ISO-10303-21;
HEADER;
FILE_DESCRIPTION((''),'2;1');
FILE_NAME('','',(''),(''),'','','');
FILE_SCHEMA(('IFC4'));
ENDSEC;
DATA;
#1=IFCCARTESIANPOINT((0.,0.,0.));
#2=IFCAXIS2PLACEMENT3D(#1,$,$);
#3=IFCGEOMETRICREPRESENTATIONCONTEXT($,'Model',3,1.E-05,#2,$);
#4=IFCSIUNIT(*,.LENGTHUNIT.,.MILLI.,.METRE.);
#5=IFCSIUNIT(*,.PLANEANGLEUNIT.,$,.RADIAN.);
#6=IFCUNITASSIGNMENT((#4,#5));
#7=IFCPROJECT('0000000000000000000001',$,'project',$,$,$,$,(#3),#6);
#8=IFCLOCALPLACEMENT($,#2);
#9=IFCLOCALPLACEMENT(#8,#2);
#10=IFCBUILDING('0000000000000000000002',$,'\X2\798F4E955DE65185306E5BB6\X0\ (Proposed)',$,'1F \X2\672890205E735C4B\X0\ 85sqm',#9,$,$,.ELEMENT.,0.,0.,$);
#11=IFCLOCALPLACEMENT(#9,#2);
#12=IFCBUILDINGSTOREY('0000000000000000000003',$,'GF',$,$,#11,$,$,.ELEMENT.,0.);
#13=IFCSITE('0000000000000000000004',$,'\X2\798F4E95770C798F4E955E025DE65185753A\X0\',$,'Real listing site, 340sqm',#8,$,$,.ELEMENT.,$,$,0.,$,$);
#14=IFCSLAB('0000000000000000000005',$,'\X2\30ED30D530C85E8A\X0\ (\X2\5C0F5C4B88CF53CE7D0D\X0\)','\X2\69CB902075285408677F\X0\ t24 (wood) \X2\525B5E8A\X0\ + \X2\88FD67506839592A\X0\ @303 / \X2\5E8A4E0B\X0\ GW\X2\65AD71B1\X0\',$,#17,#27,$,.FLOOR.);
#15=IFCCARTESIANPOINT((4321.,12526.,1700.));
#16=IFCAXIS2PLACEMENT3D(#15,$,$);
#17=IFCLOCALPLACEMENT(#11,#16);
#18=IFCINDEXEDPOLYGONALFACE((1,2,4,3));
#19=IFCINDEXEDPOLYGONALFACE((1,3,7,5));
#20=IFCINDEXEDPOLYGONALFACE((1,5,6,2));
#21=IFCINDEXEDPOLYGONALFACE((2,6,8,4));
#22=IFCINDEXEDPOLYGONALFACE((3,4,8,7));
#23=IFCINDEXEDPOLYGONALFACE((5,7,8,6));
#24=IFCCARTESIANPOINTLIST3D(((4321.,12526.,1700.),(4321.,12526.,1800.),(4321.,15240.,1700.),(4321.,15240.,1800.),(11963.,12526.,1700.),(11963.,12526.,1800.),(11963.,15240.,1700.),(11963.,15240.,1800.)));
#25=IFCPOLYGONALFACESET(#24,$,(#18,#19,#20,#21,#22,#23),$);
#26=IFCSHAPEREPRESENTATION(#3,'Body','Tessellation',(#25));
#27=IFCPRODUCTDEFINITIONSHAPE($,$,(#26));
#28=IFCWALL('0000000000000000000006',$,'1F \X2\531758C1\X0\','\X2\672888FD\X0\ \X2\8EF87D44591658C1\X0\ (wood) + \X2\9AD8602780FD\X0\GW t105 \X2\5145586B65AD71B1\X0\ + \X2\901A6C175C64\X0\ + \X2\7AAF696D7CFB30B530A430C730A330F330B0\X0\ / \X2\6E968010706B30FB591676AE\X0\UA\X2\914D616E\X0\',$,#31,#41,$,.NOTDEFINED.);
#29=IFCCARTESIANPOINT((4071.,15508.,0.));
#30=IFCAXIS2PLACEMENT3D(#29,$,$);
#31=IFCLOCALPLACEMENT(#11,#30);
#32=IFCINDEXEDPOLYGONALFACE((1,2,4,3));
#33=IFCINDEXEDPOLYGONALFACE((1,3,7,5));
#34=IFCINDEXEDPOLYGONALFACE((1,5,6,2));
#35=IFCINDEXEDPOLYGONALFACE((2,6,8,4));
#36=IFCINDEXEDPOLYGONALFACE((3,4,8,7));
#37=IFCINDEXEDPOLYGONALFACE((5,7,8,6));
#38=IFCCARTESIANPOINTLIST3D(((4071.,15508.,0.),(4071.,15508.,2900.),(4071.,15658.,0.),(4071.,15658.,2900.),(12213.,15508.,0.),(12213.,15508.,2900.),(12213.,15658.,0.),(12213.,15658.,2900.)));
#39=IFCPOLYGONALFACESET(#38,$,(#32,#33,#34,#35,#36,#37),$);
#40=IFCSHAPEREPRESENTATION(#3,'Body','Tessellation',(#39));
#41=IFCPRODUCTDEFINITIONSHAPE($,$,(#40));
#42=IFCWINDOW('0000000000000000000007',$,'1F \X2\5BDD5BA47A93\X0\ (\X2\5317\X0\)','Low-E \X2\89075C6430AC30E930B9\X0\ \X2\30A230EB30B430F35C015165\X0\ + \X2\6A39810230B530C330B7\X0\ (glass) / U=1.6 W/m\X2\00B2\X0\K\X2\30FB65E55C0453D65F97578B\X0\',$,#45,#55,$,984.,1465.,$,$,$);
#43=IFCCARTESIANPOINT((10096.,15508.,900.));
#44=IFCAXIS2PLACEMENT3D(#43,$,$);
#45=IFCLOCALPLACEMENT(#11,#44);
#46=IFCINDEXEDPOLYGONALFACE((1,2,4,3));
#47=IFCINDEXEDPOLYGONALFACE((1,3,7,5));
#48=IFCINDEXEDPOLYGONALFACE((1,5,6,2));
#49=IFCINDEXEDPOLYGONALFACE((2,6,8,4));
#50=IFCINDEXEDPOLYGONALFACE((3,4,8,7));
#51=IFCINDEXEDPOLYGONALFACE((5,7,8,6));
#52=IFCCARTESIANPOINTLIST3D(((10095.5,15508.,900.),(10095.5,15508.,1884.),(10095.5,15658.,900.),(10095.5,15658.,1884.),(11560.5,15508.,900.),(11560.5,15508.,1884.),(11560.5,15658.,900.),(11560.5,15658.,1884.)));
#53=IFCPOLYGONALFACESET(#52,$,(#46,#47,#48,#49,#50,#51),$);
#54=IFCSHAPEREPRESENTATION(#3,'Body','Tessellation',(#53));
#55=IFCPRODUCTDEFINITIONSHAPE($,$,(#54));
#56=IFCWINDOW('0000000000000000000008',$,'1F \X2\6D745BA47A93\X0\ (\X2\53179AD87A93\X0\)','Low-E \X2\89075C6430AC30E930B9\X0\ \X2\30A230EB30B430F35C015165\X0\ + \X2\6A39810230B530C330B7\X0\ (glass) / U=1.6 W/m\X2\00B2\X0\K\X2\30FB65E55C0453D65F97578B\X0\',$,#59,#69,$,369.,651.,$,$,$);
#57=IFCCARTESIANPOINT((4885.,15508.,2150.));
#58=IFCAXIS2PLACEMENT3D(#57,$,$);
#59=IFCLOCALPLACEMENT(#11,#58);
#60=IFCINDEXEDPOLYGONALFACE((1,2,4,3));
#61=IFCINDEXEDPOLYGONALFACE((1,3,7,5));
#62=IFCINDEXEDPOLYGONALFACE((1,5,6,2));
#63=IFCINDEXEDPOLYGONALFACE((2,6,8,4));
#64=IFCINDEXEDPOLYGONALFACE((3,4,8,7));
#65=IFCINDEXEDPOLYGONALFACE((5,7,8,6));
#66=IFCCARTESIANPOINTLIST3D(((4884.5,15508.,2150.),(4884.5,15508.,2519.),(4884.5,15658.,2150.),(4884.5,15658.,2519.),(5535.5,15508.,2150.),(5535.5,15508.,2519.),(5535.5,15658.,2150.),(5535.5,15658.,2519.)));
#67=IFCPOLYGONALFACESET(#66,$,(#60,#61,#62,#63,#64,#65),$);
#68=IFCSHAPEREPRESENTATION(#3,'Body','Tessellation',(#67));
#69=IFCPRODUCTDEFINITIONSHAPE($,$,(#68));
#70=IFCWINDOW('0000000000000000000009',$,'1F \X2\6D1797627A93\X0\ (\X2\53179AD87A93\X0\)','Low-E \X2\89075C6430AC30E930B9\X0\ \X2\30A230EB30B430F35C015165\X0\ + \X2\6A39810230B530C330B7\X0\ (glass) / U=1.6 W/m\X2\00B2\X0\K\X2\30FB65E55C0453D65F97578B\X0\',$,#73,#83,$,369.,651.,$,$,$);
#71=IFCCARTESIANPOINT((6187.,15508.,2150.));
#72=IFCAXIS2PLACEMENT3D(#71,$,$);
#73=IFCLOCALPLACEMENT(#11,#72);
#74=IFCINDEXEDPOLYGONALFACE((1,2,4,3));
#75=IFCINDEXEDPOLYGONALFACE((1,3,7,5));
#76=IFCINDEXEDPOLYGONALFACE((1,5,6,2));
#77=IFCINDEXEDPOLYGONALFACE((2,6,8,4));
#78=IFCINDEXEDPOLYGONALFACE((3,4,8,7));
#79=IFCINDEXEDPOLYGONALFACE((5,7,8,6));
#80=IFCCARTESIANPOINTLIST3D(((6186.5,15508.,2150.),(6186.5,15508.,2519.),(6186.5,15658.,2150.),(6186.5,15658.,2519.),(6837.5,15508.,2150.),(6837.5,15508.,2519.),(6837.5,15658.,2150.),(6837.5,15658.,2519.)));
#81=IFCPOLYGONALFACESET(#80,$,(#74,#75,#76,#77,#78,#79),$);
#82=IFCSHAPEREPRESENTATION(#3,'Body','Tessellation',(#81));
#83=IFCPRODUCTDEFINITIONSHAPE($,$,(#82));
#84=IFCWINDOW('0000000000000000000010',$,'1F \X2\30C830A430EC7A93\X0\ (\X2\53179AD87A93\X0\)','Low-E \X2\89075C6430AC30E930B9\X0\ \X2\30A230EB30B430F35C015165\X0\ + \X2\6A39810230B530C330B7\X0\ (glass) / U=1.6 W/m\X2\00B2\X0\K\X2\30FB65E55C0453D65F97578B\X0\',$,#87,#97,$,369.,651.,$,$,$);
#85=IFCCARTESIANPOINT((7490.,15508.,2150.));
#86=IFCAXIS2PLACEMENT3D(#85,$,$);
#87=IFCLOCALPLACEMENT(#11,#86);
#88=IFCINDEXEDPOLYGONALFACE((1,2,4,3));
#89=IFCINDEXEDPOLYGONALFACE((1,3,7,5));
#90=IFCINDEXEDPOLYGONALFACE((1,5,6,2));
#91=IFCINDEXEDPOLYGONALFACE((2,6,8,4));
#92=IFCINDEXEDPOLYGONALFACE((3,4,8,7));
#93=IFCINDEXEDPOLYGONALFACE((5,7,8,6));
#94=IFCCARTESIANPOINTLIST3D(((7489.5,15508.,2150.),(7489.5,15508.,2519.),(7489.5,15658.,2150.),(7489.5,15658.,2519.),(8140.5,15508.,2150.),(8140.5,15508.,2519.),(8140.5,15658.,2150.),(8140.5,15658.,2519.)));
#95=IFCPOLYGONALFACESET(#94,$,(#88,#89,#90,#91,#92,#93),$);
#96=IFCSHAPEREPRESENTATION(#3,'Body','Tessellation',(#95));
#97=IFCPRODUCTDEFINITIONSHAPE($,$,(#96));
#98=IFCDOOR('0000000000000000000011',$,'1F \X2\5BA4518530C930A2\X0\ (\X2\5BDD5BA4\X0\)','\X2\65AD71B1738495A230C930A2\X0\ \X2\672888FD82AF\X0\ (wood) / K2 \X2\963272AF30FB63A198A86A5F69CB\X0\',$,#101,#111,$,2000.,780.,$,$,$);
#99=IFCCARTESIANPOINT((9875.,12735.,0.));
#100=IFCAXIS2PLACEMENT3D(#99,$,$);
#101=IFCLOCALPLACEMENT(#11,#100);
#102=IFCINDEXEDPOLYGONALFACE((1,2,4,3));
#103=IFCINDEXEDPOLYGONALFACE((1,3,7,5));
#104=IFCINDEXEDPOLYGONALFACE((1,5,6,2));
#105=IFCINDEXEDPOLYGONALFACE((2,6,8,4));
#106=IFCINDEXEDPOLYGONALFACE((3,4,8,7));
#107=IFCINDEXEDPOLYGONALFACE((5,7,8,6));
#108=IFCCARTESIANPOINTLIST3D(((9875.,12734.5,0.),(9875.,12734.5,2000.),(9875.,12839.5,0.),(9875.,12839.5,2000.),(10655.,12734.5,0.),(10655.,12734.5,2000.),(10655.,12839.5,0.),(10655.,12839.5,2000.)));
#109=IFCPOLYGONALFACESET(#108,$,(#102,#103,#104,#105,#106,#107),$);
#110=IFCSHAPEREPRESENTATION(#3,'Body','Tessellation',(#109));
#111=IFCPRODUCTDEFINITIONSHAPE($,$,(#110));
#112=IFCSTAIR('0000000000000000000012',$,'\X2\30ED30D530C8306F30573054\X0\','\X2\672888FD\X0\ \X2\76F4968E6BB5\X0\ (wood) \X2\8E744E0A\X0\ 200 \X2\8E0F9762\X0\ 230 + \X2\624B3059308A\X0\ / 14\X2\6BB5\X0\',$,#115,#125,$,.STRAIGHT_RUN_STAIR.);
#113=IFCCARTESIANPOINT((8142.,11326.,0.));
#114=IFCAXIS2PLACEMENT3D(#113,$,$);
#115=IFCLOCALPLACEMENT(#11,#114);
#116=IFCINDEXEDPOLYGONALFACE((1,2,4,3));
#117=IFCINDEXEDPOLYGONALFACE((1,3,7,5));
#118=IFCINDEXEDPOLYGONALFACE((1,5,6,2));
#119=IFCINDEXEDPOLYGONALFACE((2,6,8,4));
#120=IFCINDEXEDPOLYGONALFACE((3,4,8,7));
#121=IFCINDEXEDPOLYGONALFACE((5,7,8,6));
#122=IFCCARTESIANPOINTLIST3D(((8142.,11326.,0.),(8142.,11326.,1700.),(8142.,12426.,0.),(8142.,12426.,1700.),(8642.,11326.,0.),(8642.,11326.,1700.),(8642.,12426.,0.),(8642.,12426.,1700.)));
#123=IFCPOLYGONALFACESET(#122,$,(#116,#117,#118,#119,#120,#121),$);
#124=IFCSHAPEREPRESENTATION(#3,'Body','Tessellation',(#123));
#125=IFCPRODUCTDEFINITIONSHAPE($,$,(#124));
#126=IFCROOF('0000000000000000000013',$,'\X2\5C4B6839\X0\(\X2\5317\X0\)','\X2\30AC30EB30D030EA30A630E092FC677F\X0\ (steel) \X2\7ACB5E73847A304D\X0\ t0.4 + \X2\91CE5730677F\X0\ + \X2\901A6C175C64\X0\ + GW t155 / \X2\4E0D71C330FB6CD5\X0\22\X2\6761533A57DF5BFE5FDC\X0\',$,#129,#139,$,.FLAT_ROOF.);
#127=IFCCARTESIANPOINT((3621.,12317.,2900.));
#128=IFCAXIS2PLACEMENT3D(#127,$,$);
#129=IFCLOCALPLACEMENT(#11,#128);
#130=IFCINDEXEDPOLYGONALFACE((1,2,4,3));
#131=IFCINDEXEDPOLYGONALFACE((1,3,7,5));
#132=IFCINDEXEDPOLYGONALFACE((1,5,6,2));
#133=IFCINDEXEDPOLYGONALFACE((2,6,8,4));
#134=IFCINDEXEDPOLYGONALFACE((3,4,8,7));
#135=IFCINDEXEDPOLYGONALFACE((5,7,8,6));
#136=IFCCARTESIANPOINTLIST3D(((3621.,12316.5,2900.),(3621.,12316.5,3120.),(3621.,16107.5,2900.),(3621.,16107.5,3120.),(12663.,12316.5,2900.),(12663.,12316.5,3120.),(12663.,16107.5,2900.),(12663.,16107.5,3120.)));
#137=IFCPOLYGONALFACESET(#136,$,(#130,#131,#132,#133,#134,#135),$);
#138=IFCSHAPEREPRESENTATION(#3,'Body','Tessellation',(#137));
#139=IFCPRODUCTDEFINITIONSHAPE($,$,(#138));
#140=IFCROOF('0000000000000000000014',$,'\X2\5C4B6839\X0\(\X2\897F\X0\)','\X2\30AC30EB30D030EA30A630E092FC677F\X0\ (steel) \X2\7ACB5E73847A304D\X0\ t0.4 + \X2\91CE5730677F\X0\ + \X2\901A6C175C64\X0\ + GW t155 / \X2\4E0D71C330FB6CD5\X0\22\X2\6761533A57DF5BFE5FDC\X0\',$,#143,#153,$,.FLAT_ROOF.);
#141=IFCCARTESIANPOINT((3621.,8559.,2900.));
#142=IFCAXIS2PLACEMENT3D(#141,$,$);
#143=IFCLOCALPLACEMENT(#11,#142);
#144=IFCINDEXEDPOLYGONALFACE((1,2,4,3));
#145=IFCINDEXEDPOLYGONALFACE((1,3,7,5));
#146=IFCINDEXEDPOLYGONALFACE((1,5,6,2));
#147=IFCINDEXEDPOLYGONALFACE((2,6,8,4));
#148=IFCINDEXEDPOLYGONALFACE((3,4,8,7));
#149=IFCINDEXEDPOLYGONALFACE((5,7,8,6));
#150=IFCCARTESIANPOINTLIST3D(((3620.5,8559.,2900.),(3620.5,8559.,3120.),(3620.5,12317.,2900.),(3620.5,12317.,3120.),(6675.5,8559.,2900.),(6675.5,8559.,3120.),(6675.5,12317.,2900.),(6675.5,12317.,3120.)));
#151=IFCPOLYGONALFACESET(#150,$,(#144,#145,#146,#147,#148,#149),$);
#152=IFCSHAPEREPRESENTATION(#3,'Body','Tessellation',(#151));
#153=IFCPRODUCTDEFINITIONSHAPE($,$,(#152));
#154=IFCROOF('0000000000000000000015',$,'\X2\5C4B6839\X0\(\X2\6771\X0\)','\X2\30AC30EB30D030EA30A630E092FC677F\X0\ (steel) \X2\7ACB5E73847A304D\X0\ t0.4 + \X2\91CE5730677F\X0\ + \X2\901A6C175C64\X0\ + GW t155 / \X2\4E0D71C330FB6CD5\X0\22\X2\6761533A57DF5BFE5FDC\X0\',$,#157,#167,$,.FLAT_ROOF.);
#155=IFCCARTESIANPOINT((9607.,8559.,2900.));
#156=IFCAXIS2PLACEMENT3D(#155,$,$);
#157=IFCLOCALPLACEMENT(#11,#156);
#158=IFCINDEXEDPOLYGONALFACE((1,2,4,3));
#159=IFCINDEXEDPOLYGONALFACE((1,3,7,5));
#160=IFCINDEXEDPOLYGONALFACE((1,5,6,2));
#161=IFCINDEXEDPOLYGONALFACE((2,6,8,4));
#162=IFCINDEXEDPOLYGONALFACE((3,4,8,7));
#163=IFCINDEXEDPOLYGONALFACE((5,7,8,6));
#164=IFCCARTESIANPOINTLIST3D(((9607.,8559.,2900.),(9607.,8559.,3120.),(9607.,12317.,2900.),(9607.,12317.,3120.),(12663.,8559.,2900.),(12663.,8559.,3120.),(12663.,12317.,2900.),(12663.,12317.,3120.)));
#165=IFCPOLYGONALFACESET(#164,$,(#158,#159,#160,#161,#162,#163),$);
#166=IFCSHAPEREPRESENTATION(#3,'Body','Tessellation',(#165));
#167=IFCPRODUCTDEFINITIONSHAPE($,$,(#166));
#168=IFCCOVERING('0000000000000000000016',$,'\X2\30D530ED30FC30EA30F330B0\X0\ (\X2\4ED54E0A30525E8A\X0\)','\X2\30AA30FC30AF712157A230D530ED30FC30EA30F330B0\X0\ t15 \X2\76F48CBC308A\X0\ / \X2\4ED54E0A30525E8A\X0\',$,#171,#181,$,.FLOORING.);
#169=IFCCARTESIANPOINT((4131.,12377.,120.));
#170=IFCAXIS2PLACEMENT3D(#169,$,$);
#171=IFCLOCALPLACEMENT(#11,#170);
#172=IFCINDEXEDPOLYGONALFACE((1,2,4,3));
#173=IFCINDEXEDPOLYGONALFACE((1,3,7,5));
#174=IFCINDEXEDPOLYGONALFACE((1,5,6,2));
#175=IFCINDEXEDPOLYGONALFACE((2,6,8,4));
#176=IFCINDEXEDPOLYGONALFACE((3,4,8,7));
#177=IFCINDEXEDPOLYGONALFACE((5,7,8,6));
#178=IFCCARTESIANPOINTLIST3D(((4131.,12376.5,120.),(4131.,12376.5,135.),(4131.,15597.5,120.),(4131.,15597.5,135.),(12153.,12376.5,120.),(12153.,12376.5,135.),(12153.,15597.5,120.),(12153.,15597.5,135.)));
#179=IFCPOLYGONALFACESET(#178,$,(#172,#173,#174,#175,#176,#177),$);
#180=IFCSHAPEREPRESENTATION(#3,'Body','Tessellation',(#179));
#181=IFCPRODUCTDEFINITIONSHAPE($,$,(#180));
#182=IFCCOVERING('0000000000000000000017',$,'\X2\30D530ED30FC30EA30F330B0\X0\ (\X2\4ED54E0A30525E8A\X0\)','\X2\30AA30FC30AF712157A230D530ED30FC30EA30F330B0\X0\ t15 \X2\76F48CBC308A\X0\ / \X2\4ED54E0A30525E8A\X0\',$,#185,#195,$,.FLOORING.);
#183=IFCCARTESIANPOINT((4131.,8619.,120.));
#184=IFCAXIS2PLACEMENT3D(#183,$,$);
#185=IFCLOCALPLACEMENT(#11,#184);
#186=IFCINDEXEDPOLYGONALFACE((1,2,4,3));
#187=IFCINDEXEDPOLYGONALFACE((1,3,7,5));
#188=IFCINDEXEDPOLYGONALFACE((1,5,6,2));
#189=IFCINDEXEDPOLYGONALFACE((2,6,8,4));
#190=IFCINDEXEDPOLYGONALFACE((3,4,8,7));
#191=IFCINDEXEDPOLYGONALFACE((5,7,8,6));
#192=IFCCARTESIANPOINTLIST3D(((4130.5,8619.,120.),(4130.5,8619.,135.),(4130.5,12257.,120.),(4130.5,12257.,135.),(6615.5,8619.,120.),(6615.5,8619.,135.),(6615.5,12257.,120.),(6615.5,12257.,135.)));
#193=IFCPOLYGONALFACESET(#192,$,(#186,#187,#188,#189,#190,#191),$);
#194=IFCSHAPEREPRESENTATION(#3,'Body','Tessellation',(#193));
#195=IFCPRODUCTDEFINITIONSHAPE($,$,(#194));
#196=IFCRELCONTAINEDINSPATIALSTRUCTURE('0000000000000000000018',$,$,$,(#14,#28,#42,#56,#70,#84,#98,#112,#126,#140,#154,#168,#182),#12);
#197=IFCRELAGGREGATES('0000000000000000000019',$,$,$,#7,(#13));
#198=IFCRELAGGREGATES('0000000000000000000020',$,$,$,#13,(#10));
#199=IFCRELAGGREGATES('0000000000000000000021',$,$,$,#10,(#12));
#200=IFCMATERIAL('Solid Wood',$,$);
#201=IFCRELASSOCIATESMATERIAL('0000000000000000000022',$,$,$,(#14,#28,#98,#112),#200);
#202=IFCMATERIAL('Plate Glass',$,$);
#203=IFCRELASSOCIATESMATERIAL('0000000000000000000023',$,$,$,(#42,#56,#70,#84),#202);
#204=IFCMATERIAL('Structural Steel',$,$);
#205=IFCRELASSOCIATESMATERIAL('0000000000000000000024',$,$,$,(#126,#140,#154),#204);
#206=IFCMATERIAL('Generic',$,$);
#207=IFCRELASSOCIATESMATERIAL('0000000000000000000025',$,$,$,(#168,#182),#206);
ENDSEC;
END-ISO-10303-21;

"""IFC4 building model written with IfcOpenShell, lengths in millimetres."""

from ifc_helpers import new_model, si_unit, frame, frame_2d, origin, place, context, project, spatial, rectangle, extrude, material, element, fill, save


model = new_model("IFC4")

# Units and contexts
model_context = context("Model", 3, precision=1e-05, world=origin())
ifc_project = project(units=[si_unit("LENGTHUNIT", "METRE", prefix="MILLI"), si_unit("PLANEANGLEUNIT", "RADIAN")], contexts=[model_context])

# Site, building, storey
site_placement = place(None, origin())
site = spatial("IfcSite", under=ifc_project, at=site_placement, Name="福井県福井市左内町", ObjectType="Real listing site, 340sqm", CompositionType="ELEMENT", RefElevation=0.0)
building_placement = place(site_placement, origin())
building = spatial("IfcBuilding", under=site, at=building_placement, Name="福井左内の家 (Proposed)", ObjectType="1F 木造平屋 85sqm", CompositionType="ELEMENT", ElevationOfRefHeight=0.0, ElevationOfTerrain=0.0)
storey_placement = place(building_placement, origin())
storey = spatial("IfcBuildingStorey", under=building, at=storey_placement, Name="GF", CompositionType="ELEMENT", Elevation=0.0)

# Slab
ifc_material_1 = material(Name="Solid Wood")
slab_1_placement = place(storey_placement, frame((4321.0, 12526.0, 1700.0)))
element("IfcSlab", 1, at=slab_1_placement, inside=storey, material=ifc_material_1, Name="ロフト床 (小屋裏収納)", Description="構造用合板 t24 (wood) 剛床 + 製材根太 @303 / 床下 GW断熱", PredefinedType="FLOOR", context=model_context, shape_type="SweptSolid", body=[
    extrude(rectangle(XDim=7642.0, YDim=2714.0, at=frame_2d((3821.0, 1357.0))), frame((4321.0, 12526.0, 1700.0)), (0.0, 0.0, 1.0), 100.0),
])

# Wall, openings, windows
wall_1_placement = place(storey_placement, frame((4071.0, 15508.0, 0.0)))
wall_1 = element("IfcWall", 2, at=wall_1_placement, inside=storey, material=ifc_material_1, Name="1F 北壁", Description="木製 軸組外壁 (wood) + 高性能GW t105 充填断熱 + 通気層 + 窯業系サイディング / 準耐火・外皮UA配慮", PredefinedType="NOTDEFINED", context=model_context, shape_type="SweptSolid", body=[
    extrude(rectangle(XDim=8142.0, YDim=150.0, at=frame_2d((4071.0, 75.0))), frame((4071.0, 15508.0, 0.0)), (0.0, 0.0, 1.0), 2900.0),
])
opening_1_placement = place(storey_placement, frame((10096.0, 15508.0, 900.0)))
opening_1 = element("IfcOpeningElement", 3, at=opening_1_placement, cuts=wall_1, PredefinedType="NOTDEFINED", context=model_context, shape_type="SweptSolid", body=[
    extrude(rectangle(XDim=1465.0, YDim=150.0, at=frame_2d((732.0, 75.0))), frame((10096.0, 15508.0, 900.0)), (0.0, 0.0, 1.0), 984.0),
])
opening_2_placement = place(storey_placement, frame((4885.0, 15508.0, 2150.0)))
opening_2 = element("IfcOpeningElement", 4, at=opening_2_placement, cuts=wall_1, PredefinedType="NOTDEFINED", context=model_context, shape_type="SweptSolid", body=[
    extrude(rectangle(XDim=651.0, YDim=150.0, at=frame_2d((325.0, 75.0))), frame((4885.0, 15508.0, 2150.0)), (0.0, 0.0, 1.0), 369.0),
])
opening_3_placement = place(storey_placement, frame((6187.0, 15508.0, 2150.0)))
opening_3 = element("IfcOpeningElement", 5, at=opening_3_placement, cuts=wall_1, PredefinedType="NOTDEFINED", context=model_context, shape_type="SweptSolid", body=[
    extrude(rectangle(XDim=651.0, YDim=150.0, at=frame_2d((325.0, 75.0))), frame((6187.0, 15508.0, 2150.0)), (0.0, 0.0, 1.0), 369.0),
])
opening_4_placement = place(storey_placement, frame((7490.0, 15508.0, 2150.0)))
opening_4 = element("IfcOpeningElement", 6, at=opening_4_placement, cuts=wall_1, PredefinedType="NOTDEFINED", context=model_context, shape_type="SweptSolid", body=[
    extrude(rectangle(XDim=651.0, YDim=150.0, at=frame_2d((325.0, 75.0))), frame((7490.0, 15508.0, 2150.0)), (0.0, 0.0, 1.0), 369.0),
])
ifc_material_2 = material(Name="Plate Glass")
window_1_placement = place(storey_placement, frame((10096.0, 15508.0, 900.0)))
window_1 = element("IfcWindow", 7, at=window_1_placement, inside=storey, material=ifc_material_2, Name="1F 寝室窓 (北)", Description="Low-E 複層ガラス アルゴン封入 + 樹脂サッシ (glass) / U=1.6 W/m²K・日射取得型", OverallHeight=984.0, OverallWidth=1465.0, context=model_context, shape_type="SweptSolid", body=[
    extrude(rectangle(XDim=1465.0, YDim=150.0, at=frame_2d((732.0, 75.0))), frame((10096.0, 15508.0, 900.0)), (0.0, 0.0, 1.0), 984.0),
])
fill(opening_1, window_1)
window_2_placement = place(storey_placement, frame((4885.0, 15508.0, 2150.0)))
window_2 = element("IfcWindow", 8, at=window_2_placement, inside=storey, material=ifc_material_2, Name="1F 浴室窓 (北高窓)", Description="Low-E 複層ガラス アルゴン封入 + 樹脂サッシ (glass) / U=1.6 W/m²K・日射取得型", OverallHeight=369.0, OverallWidth=651.0, context=model_context, shape_type="SweptSolid", body=[
    extrude(rectangle(XDim=651.0, YDim=150.0, at=frame_2d((325.0, 75.0))), frame((4885.0, 15508.0, 2150.0)), (0.0, 0.0, 1.0), 369.0),
])
fill(opening_2, window_2)
window_3_placement = place(storey_placement, frame((6187.0, 15508.0, 2150.0)))
window_3 = element("IfcWindow", 9, at=window_3_placement, inside=storey, material=ifc_material_2, Name="1F 洗面窓 (北高窓)", Description="Low-E 複層ガラス アルゴン封入 + 樹脂サッシ (glass) / U=1.6 W/m²K・日射取得型", OverallHeight=369.0, OverallWidth=651.0, context=model_context, shape_type="SweptSolid", body=[
    extrude(rectangle(XDim=651.0, YDim=150.0, at=frame_2d((325.0, 75.0))), frame((6187.0, 15508.0, 2150.0)), (0.0, 0.0, 1.0), 369.0),
])
fill(opening_3, window_3)
window_4_placement = place(storey_placement, frame((7490.0, 15508.0, 2150.0)))
window_4 = element("IfcWindow", 10, at=window_4_placement, inside=storey, material=ifc_material_2, Name="1F トイレ窓 (北高窓)", Description="Low-E 複層ガラス アルゴン封入 + 樹脂サッシ (glass) / U=1.6 W/m²K・日射取得型", OverallHeight=369.0, OverallWidth=651.0, context=model_context, shape_type="SweptSolid", body=[
    extrude(rectangle(XDim=651.0, YDim=150.0, at=frame_2d((325.0, 75.0))), frame((7490.0, 15508.0, 2150.0)), (0.0, 0.0, 1.0), 369.0),
])
fill(opening_4, window_4)

# Door
door_1_placement = place(storey_placement, frame((9875.0, 12735.0, 0.0)))
element("IfcDoor", 11, at=door_1_placement, inside=storey, material=ifc_material_1, Name="1F 室内ドア (寝室)", Description="断熱玄関ドア 木製芯 (wood) / K2 防犯・採風機構", OverallHeight=2000.0, OverallWidth=780.0, context=model_context, shape_type="SweptSolid", body=[
    extrude(rectangle(XDim=780.0, YDim=105.0, at=frame_2d((390.0, 52.0))), frame((9875.0, 12735.0, 0.0)), (0.0, 0.0, 1.0), 2000.0),
])

# Stair
stair_placement = place(storey_placement, frame((8142.0, 11326.0, 0.0)))
element("IfcStair", 12, at=stair_placement, inside=storey, material=ifc_material_1, Name="ロフトはしご", Description="木製 直階段 (wood) 蹴上 200 踏面 230 + 手すり / 14段", PredefinedType="STRAIGHT_RUN_STAIR", context=model_context, shape_type="SweptSolid", body=[
    extrude(rectangle(XDim=500.0, YDim=1100.0, at=frame_2d((250.0, 550.0))), frame((8142.0, 11326.0, 0.0)), (0.0, 0.0, 1.0), 1700.0),
])

# Roofs
ifc_material_3 = material(Name="Structural Steel")
roof_1_placement = place(storey_placement, frame((3621.0, 12317.0, 2900.0)))
element("IfcRoof", 13, at=roof_1_placement, inside=storey, material=ifc_material_3, Name="屋根(北)", Description="ガルバリウム鋼板 (steel) 立平葺き t0.4 + 野地板 + 通気層 + GW t155 / 不燃・法22条区域対応", PredefinedType="FLAT_ROOF", context=model_context, shape_type="SweptSolid", body=[
    extrude(rectangle(XDim=9042.0, YDim=3791.0, at=frame_2d((4521.0, 1895.0))), frame((3621.0, 12317.0, 2900.0)), (0.0, 0.0, 1.0), 220.0),
])
roof_2_placement = place(storey_placement, frame((3621.0, 8559.0, 2900.0)))
element("IfcRoof", 14, at=roof_2_placement, inside=storey, material=ifc_material_3, Name="屋根(西)", Description="ガルバリウム鋼板 (steel) 立平葺き t0.4 + 野地板 + 通気層 + GW t155 / 不燃・法22条区域対応", PredefinedType="FLAT_ROOF", context=model_context, shape_type="SweptSolid", body=[
    extrude(rectangle(XDim=3055.0, YDim=3758.0, at=frame_2d((1527.0, 1879.0))), frame((3621.0, 8559.0, 2900.0)), (0.0, 0.0, 1.0), 220.0),
])
roof_3_placement = place(storey_placement, frame((9607.0, 8559.0, 2900.0)))
element("IfcRoof", 15, at=roof_3_placement, inside=storey, material=ifc_material_3, Name="屋根(東)", Description="ガルバリウム鋼板 (steel) 立平葺き t0.4 + 野地板 + 通気層 + GW t155 / 不燃・法22条区域対応", PredefinedType="FLAT_ROOF", context=model_context, shape_type="SweptSolid", body=[
    extrude(rectangle(XDim=3056.0, YDim=3758.0, at=frame_2d((1528.0, 1879.0))), frame((9607.0, 8559.0, 2900.0)), (0.0, 0.0, 1.0), 220.0),
])

# Coverings
ifc_material_4 = material(Name="Generic")
covering_1_placement = place(storey_placement, frame((4131.0, 12377.0, 120.0)))
element("IfcCovering", 16, at=covering_1_placement, inside=storey, material=ifc_material_4, Name="フローリング (仕上げ床)", Description="オーク無垢フローリング t15 直貼り / 仕上げ床", PredefinedType="FLOORING", context=model_context, shape_type="SweptSolid", body=[
    extrude(rectangle(XDim=8022.0, YDim=3221.0, at=frame_2d((4011.0, 1610.0))), frame((4131.0, 12377.0, 120.0)), (0.0, 0.0, 1.0), 15.0),
])
covering_2_placement = place(storey_placement, frame((4131.0, 8619.0, 120.0)))
element("IfcCovering", 17, at=covering_2_placement, inside=storey, material=ifc_material_4, Name="フローリング (仕上げ床)", Description="オーク無垢フローリング t15 直貼り / 仕上げ床", PredefinedType="FLOORING", context=model_context, shape_type="SweptSolid", body=[
    extrude(rectangle(XDim=2485.0, YDim=3638.0, at=frame_2d((1242.0, 1819.0))), frame((4131.0, 8619.0, 120.0)), (0.0, 0.0, 1.0), 15.0),
])

save(model, "model.ifc")
